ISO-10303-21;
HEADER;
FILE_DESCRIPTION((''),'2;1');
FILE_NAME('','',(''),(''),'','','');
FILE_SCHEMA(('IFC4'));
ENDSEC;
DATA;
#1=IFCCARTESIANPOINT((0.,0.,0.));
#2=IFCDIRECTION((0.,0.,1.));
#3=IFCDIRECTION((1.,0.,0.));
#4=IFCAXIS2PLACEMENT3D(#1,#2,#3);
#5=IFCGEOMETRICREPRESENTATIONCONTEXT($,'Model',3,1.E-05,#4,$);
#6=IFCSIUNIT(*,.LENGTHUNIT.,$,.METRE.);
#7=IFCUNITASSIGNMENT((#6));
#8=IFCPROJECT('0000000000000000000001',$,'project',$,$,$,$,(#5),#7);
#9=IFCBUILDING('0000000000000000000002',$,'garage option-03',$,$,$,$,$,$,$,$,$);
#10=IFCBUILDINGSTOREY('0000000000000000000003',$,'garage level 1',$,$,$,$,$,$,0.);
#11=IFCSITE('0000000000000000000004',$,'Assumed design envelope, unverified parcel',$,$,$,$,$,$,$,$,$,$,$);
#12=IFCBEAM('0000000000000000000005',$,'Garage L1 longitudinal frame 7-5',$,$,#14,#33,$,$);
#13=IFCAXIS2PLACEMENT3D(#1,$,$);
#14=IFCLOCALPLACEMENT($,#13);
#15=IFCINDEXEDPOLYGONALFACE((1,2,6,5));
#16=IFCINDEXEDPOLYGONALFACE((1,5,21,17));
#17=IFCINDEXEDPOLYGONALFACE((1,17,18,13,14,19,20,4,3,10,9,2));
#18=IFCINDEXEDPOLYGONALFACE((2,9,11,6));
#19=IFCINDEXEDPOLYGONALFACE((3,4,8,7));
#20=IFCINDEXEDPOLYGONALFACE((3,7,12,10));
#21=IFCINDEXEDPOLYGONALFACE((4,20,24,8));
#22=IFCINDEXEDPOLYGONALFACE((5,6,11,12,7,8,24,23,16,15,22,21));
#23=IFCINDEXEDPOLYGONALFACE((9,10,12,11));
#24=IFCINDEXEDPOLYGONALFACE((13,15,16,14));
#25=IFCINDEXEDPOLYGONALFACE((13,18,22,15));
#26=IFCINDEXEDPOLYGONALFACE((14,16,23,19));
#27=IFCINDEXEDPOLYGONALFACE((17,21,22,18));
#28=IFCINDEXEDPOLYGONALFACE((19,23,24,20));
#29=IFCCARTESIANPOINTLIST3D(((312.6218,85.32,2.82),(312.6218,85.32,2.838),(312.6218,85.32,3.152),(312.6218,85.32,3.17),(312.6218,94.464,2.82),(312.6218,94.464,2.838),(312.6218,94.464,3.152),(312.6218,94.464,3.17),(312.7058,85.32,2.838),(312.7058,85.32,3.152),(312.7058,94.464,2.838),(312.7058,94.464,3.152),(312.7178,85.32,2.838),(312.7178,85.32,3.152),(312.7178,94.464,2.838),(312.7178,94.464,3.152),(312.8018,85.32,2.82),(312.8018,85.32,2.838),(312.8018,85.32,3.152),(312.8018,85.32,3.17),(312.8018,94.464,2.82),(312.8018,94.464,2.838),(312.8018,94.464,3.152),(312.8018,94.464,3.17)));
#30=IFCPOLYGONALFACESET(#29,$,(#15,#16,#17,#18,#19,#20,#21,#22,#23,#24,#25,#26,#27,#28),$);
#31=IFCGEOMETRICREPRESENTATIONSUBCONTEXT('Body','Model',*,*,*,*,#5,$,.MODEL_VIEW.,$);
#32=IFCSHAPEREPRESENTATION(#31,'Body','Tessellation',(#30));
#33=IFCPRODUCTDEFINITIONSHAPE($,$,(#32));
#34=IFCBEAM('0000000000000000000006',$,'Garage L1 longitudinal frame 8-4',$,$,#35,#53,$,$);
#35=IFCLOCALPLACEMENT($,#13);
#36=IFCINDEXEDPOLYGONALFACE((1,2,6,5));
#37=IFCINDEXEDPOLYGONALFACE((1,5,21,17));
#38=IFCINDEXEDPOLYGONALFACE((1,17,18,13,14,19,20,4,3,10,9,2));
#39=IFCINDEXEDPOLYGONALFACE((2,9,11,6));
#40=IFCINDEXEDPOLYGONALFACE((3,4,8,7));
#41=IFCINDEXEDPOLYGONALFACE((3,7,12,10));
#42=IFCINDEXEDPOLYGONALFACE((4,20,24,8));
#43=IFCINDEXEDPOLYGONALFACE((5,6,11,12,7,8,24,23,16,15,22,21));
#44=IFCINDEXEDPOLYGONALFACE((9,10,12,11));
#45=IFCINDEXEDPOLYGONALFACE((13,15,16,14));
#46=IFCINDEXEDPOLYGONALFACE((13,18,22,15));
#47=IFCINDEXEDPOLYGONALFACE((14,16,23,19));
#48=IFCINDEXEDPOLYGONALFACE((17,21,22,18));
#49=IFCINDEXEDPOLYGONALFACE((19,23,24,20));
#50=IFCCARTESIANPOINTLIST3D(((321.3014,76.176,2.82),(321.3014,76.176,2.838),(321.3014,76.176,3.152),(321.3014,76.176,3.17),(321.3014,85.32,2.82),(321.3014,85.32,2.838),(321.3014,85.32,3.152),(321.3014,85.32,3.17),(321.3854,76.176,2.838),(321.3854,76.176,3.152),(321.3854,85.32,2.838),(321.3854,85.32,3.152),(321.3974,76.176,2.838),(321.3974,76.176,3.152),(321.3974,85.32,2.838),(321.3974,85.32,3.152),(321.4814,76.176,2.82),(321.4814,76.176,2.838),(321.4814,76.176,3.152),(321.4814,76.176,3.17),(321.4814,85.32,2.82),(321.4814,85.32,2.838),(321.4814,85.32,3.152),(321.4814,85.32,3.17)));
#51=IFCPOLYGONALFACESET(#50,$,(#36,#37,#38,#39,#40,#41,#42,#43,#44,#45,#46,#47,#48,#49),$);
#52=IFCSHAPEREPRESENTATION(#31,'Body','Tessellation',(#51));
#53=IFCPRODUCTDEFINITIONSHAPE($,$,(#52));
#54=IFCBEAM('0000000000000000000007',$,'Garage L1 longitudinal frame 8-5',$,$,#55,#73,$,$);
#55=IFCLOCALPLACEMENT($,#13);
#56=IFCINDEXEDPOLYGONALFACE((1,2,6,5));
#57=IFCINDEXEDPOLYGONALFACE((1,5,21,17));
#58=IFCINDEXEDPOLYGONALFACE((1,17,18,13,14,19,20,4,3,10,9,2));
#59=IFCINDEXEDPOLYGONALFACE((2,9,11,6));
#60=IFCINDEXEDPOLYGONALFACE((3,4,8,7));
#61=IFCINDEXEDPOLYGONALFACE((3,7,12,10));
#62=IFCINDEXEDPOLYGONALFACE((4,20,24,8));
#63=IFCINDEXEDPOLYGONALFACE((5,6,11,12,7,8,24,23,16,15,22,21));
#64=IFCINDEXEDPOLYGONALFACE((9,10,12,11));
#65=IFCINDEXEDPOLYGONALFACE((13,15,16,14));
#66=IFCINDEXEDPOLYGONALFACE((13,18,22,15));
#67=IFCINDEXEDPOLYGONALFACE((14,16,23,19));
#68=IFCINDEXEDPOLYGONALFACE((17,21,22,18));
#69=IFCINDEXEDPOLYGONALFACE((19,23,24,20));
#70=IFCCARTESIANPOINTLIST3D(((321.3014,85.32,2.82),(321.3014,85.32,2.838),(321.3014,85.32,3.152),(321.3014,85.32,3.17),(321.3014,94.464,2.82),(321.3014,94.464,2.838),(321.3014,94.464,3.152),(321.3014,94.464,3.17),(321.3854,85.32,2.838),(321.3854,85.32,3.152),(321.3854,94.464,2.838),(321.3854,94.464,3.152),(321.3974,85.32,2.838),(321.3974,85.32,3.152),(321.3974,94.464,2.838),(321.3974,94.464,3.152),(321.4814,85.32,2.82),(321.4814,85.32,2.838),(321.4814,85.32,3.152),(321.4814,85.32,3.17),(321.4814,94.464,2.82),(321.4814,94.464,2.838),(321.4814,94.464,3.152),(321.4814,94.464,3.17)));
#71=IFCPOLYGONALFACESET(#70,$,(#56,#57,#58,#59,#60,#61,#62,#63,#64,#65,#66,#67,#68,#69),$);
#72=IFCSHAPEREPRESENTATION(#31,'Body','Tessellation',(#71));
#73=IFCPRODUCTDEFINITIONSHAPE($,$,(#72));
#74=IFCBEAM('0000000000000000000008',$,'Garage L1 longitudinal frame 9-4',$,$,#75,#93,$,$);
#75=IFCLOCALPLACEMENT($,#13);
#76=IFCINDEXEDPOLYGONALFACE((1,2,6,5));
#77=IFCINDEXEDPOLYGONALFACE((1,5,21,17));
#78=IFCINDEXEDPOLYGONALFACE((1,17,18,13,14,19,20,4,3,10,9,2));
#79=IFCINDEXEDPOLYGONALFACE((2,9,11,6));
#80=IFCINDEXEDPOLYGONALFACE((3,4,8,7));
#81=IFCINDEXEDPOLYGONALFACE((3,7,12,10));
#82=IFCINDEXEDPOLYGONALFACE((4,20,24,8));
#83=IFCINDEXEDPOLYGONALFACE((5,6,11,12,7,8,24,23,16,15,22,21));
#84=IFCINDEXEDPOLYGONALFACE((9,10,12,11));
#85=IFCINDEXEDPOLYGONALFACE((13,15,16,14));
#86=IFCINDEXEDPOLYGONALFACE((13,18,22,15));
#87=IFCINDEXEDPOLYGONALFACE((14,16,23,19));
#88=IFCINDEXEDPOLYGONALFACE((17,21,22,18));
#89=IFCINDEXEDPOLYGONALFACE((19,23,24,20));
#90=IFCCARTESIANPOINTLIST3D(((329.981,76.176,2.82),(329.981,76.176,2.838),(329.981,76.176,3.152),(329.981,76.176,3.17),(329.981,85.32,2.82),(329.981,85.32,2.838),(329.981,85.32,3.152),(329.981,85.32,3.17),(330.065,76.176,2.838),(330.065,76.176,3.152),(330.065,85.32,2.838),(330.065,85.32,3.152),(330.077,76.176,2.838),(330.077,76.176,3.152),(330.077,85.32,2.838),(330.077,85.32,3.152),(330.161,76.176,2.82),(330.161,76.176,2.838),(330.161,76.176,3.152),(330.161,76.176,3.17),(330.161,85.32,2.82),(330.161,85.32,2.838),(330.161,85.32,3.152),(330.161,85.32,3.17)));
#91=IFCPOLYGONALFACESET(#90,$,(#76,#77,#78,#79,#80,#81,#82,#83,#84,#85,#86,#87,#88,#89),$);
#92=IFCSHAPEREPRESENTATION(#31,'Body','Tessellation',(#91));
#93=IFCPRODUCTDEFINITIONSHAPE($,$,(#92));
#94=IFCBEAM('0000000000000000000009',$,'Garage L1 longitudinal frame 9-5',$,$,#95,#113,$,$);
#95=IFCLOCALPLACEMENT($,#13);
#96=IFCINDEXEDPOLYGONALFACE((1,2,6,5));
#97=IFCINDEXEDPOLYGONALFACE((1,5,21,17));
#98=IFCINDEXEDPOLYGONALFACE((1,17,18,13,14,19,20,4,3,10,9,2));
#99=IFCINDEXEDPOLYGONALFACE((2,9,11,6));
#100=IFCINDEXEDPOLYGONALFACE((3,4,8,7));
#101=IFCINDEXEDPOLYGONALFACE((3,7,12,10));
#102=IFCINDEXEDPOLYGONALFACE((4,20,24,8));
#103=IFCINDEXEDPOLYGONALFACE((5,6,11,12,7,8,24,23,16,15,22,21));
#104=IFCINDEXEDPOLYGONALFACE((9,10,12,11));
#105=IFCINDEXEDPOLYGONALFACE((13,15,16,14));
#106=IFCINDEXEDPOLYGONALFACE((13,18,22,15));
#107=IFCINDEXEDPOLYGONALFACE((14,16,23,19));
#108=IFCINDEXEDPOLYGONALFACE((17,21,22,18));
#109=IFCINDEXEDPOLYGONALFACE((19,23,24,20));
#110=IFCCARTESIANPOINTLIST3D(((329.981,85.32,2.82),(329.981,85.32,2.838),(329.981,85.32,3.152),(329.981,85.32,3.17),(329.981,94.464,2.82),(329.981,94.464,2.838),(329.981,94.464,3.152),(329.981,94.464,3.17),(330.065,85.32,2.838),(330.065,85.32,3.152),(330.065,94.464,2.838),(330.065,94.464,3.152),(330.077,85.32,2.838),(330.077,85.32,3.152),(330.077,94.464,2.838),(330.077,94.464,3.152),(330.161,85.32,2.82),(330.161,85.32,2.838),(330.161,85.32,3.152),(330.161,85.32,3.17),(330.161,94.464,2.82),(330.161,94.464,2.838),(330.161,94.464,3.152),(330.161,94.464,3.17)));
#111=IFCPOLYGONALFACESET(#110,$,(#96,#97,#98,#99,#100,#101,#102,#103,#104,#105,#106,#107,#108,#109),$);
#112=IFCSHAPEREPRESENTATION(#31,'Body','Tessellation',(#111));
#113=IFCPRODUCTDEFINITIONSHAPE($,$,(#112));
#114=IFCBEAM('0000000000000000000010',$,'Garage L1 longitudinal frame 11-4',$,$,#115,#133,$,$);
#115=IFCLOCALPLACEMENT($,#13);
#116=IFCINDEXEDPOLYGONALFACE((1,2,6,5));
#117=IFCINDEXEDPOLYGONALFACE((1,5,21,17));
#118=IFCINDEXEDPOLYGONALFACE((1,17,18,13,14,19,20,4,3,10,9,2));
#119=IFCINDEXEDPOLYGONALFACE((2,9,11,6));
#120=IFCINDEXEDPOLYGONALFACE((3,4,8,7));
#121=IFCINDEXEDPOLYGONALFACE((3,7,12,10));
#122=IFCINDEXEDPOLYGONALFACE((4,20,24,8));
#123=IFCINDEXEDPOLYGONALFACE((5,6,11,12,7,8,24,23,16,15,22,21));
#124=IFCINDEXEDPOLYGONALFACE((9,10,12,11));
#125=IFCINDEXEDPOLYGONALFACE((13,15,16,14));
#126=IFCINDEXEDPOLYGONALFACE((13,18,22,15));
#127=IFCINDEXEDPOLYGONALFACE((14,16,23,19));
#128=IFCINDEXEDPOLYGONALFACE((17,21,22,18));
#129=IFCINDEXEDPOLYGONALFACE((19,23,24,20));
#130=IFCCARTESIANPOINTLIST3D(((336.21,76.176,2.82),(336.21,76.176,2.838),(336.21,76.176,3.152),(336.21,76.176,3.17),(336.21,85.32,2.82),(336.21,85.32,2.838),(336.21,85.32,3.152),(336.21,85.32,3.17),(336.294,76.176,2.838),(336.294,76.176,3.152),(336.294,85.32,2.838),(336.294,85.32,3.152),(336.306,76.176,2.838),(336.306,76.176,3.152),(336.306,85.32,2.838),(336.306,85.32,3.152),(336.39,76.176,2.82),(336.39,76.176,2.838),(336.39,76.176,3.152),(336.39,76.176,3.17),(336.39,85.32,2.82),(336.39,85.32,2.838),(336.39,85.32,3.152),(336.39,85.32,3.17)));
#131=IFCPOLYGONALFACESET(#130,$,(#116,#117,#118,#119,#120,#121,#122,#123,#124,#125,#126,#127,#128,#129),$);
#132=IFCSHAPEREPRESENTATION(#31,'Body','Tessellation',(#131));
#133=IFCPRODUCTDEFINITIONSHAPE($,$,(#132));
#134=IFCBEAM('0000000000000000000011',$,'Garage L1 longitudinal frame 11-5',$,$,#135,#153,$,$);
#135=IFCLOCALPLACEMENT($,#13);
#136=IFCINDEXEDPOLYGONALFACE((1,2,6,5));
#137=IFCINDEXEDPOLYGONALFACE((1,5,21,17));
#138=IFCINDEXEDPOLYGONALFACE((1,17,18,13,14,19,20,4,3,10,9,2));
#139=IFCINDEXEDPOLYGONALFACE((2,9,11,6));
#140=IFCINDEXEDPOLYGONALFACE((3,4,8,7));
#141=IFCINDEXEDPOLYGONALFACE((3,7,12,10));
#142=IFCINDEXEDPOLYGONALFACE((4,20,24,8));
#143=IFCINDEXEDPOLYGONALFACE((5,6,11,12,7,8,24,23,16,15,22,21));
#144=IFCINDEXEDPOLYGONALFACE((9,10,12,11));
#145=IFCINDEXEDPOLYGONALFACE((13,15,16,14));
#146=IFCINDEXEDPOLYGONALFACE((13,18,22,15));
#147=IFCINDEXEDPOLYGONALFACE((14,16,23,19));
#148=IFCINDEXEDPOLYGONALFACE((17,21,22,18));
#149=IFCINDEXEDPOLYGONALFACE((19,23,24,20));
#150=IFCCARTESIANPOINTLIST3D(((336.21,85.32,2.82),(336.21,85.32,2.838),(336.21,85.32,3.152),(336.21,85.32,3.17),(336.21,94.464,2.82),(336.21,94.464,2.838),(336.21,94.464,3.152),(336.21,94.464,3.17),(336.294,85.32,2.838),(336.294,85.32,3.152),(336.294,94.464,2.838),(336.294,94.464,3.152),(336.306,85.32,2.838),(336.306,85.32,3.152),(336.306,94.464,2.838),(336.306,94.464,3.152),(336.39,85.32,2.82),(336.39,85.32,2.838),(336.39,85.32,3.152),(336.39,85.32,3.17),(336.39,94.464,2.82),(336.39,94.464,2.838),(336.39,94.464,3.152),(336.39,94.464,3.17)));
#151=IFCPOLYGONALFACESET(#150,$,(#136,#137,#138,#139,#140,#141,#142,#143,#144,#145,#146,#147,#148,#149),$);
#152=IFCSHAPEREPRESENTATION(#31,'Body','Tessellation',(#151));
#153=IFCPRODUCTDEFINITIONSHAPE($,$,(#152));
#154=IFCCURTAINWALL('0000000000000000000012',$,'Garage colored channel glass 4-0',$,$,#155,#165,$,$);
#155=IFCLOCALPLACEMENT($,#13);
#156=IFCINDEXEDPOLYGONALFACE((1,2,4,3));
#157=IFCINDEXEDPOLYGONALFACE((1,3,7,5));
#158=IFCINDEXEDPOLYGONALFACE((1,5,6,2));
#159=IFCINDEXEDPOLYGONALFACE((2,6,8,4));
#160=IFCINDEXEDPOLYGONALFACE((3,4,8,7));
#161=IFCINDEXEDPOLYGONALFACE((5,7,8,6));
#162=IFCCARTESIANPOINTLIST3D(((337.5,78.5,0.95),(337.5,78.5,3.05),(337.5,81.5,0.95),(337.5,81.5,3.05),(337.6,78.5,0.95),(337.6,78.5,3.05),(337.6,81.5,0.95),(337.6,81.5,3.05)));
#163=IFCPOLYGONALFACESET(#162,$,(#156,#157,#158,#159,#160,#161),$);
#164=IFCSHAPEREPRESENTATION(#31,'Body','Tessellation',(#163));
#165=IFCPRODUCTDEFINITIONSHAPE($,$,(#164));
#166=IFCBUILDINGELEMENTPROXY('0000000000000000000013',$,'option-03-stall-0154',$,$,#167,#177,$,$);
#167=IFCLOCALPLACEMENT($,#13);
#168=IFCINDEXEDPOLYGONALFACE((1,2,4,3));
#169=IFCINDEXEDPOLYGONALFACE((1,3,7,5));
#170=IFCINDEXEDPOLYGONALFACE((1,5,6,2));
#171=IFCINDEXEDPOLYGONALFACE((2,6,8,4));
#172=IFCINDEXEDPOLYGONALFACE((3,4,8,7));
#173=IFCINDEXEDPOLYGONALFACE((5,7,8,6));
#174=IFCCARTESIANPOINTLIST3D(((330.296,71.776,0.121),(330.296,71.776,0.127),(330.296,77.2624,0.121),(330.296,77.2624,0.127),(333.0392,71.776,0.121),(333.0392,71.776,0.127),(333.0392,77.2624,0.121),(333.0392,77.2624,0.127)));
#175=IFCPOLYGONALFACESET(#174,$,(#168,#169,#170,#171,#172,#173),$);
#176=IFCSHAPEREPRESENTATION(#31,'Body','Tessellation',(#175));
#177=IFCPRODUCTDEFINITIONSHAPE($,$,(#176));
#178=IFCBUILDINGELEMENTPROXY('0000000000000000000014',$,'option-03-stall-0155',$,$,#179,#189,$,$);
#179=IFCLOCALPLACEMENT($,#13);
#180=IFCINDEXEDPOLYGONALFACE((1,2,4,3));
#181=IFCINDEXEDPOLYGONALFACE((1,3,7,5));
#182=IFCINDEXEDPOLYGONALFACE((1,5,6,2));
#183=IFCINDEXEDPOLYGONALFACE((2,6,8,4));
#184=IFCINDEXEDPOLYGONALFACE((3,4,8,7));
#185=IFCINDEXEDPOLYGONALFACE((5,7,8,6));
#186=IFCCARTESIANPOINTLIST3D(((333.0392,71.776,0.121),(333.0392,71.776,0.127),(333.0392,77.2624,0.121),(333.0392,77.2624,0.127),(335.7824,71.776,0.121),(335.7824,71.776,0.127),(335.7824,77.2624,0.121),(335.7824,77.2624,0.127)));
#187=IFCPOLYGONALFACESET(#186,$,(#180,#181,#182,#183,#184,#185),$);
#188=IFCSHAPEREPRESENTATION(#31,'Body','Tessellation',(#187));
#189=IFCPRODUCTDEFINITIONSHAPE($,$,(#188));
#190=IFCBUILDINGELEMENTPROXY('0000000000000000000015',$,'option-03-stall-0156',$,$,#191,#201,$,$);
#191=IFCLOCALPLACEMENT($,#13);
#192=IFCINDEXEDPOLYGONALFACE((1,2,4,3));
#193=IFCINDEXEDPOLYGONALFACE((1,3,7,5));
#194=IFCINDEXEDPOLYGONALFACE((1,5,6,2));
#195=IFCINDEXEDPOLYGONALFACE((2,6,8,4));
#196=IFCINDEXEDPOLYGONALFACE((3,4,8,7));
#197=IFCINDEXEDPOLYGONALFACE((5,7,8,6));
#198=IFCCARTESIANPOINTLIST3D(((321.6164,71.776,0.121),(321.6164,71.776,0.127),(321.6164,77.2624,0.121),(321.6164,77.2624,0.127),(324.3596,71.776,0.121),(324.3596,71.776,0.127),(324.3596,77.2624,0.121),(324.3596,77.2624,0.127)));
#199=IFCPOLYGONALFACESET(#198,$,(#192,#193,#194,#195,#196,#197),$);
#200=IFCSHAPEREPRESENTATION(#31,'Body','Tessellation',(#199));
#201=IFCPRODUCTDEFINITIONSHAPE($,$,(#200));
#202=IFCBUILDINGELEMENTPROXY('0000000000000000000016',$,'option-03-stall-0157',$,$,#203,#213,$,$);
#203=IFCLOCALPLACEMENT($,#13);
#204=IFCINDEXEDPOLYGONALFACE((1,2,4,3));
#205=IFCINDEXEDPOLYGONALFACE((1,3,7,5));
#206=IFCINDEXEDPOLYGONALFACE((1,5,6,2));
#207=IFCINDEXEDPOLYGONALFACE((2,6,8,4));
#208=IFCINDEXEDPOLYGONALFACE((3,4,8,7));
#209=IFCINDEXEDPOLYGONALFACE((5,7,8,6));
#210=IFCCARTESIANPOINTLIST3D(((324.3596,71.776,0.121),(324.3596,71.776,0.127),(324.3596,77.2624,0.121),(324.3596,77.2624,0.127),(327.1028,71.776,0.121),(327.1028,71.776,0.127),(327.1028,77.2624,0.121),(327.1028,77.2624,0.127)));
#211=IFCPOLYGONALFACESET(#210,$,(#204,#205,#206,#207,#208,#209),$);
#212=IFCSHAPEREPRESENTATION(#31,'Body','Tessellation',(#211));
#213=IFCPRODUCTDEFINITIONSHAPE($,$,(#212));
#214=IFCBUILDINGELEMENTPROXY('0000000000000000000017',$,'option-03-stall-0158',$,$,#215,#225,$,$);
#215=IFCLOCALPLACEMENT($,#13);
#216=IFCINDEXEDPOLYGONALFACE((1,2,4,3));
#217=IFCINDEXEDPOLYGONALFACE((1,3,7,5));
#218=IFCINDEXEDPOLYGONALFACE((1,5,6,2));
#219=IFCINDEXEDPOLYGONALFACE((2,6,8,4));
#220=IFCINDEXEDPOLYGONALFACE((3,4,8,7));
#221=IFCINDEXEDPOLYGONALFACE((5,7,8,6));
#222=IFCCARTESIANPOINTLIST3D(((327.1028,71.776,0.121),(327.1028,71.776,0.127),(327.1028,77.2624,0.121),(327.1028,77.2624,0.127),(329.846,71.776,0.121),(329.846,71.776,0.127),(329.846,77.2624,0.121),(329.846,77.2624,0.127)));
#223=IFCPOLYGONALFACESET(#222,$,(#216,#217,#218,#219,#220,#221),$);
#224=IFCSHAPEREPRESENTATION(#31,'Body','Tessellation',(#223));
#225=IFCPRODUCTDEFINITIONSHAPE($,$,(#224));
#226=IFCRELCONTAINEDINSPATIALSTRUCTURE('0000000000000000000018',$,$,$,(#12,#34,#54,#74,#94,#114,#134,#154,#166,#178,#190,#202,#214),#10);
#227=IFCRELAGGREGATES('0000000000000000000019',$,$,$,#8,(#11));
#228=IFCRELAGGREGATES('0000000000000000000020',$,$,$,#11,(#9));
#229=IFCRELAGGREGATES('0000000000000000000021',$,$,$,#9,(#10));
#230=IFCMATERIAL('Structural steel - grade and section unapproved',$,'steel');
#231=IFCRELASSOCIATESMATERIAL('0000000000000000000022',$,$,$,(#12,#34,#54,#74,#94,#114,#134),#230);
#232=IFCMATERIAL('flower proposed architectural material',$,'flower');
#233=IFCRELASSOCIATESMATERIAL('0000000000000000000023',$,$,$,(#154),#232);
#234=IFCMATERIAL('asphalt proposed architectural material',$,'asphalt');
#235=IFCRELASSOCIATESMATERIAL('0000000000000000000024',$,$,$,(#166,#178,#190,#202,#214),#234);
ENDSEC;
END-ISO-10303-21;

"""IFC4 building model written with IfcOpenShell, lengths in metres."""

from ifc_helpers import new_model, si_unit, frame, origin_with_axes, place, context, subcontext, project, spatial, rectangle, i_section, extrude, material, element, save


model = new_model("IFC4")

# Units and contexts
model_context = context("Model", 3, precision=1e-05, world=origin_with_axes())
body_context = subcontext(model_context, "Body", "Model", "MODEL_VIEW")
ifc_project = project(units=[si_unit("LENGTHUNIT", "METRE")], contexts=[model_context])

# Site, building, storey
site = spatial("IfcSite", under=ifc_project, Name="Assumed design envelope, unverified parcel")
building = spatial("IfcBuilding", under=site, Name="garage option-03")
storey = spatial("IfcBuildingStorey", under=building, Name="garage level 1", Elevation=0.0)

# Beams
ifc_material_1 = material(Name="Structural steel - grade and section unapproved", Category="steel")
for number, where, z_axis, x_axis, name in (
    (1, (312.7118, 85.32, 2.995), (0.0, 1.0, 0.0), (-1.0, 0.0, 0.0), "Garage L1 longitudinal frame 7-5"),
    (2, (321.3914, 76.176, 2.995), (0.0, 1.0, 0.0), (-1.0, 0.0, 0.0), "Garage L1 longitudinal frame 8-4"),
    (3, (321.3914, 85.32, 2.995), (0.0, 1.0, 0.0), (-1.0, 0.0, 0.0), "Garage L1 longitudinal frame 8-5"),
    (4, (330.071, 76.176, 2.995), (0.0, 1.0, 0.0), (-1.0, 0.0, 0.0), "Garage L1 longitudinal frame 9-4"),
    (5, (330.071, 85.32, 2.995), (0.0, 1.0, 0.0), (-1.0, 0.0, 0.0), "Garage L1 longitudinal frame 9-5"),
    (6, (336.3, 76.176, 2.995), (0.0, 1.0, 0.0), (-1.0, 0.0, 0.0), "Garage L1 longitudinal frame 11-4"),
    (7, (336.3, 85.32, 2.995), (0.0, 1.0, 0.0), (-1.0, 0.0, 0.0), "Garage L1 longitudinal frame 11-5"),
):
    element("IfcBeam", number, at=place(None, frame(where, z_axis=z_axis, x_axis=x_axis)), inside=storey, material=ifc_material_1, Name=name, context=body_context, shape_type="SweptSolid", body=[
        extrude(i_section(OverallWidth=0.18, OverallDepth=0.35, WebThickness=0.012, FlangeThickness=0.018, FilletRadius=0.0), origin_with_axes(), (0.0, 0.0, 1.0), 9.144),
    ])

# Curtain wall
ifc_material_2 = material(Name="flower proposed architectural material", Category="flower")
curtain_wall_placement = place(None, frame((337.55, 80.0, 0.95), z_axis=(0.0, 0.0, 1.0), x_axis=(1.0, 0.0, 0.0)))
element("IfcCurtainWall", 8, at=curtain_wall_placement, inside=storey, material=ifc_material_2, Name="Garage colored channel glass 4-0", context=body_context, shape_type="SweptSolid", body=[
    extrude(rectangle(XDim=0.1, YDim=3.0), origin_with_axes(), (0.0, 0.0, 1.0), 2.1),
])

# Building element proxies
ifc_material_3 = material(Name="asphalt proposed architectural material", Category="asphalt")
for number, where, z_axis, x_axis, name in (
    (9, (331.6676, 74.5192, 0.121), (0.0, 0.0, 1.0), (1.0, 0.0, 0.0), "option-03-stall-0154"),
    (10, (334.4108, 74.5192, 0.121), (0.0, 0.0, 1.0), (1.0, 0.0, 0.0), "option-03-stall-0155"),
    (11, (322.988, 74.5192, 0.121), (0.0, 0.0, 1.0), (1.0, 0.0, 0.0), "option-03-stall-0156"),
    (12, (325.7312, 74.5192, 0.121), (0.0, 0.0, 1.0), (1.0, 0.0, 0.0), "option-03-stall-0157"),
    (13, (328.4744, 74.5192, 0.121), (0.0, 0.0, 1.0), (1.0, 0.0, 0.0), "option-03-stall-0158"),
):
    element("IfcBuildingElementProxy", number, at=place(None, frame(where, z_axis=z_axis, x_axis=x_axis)), inside=storey, material=ifc_material_3, Name=name, context=body_context, shape_type="SweptSolid", body=[
        extrude(rectangle(XDim=2.7432, YDim=5.4864), origin_with_axes(), (0.0, 0.0, 1.0), 0.006),
    ])

save(model, "model.ifc")
